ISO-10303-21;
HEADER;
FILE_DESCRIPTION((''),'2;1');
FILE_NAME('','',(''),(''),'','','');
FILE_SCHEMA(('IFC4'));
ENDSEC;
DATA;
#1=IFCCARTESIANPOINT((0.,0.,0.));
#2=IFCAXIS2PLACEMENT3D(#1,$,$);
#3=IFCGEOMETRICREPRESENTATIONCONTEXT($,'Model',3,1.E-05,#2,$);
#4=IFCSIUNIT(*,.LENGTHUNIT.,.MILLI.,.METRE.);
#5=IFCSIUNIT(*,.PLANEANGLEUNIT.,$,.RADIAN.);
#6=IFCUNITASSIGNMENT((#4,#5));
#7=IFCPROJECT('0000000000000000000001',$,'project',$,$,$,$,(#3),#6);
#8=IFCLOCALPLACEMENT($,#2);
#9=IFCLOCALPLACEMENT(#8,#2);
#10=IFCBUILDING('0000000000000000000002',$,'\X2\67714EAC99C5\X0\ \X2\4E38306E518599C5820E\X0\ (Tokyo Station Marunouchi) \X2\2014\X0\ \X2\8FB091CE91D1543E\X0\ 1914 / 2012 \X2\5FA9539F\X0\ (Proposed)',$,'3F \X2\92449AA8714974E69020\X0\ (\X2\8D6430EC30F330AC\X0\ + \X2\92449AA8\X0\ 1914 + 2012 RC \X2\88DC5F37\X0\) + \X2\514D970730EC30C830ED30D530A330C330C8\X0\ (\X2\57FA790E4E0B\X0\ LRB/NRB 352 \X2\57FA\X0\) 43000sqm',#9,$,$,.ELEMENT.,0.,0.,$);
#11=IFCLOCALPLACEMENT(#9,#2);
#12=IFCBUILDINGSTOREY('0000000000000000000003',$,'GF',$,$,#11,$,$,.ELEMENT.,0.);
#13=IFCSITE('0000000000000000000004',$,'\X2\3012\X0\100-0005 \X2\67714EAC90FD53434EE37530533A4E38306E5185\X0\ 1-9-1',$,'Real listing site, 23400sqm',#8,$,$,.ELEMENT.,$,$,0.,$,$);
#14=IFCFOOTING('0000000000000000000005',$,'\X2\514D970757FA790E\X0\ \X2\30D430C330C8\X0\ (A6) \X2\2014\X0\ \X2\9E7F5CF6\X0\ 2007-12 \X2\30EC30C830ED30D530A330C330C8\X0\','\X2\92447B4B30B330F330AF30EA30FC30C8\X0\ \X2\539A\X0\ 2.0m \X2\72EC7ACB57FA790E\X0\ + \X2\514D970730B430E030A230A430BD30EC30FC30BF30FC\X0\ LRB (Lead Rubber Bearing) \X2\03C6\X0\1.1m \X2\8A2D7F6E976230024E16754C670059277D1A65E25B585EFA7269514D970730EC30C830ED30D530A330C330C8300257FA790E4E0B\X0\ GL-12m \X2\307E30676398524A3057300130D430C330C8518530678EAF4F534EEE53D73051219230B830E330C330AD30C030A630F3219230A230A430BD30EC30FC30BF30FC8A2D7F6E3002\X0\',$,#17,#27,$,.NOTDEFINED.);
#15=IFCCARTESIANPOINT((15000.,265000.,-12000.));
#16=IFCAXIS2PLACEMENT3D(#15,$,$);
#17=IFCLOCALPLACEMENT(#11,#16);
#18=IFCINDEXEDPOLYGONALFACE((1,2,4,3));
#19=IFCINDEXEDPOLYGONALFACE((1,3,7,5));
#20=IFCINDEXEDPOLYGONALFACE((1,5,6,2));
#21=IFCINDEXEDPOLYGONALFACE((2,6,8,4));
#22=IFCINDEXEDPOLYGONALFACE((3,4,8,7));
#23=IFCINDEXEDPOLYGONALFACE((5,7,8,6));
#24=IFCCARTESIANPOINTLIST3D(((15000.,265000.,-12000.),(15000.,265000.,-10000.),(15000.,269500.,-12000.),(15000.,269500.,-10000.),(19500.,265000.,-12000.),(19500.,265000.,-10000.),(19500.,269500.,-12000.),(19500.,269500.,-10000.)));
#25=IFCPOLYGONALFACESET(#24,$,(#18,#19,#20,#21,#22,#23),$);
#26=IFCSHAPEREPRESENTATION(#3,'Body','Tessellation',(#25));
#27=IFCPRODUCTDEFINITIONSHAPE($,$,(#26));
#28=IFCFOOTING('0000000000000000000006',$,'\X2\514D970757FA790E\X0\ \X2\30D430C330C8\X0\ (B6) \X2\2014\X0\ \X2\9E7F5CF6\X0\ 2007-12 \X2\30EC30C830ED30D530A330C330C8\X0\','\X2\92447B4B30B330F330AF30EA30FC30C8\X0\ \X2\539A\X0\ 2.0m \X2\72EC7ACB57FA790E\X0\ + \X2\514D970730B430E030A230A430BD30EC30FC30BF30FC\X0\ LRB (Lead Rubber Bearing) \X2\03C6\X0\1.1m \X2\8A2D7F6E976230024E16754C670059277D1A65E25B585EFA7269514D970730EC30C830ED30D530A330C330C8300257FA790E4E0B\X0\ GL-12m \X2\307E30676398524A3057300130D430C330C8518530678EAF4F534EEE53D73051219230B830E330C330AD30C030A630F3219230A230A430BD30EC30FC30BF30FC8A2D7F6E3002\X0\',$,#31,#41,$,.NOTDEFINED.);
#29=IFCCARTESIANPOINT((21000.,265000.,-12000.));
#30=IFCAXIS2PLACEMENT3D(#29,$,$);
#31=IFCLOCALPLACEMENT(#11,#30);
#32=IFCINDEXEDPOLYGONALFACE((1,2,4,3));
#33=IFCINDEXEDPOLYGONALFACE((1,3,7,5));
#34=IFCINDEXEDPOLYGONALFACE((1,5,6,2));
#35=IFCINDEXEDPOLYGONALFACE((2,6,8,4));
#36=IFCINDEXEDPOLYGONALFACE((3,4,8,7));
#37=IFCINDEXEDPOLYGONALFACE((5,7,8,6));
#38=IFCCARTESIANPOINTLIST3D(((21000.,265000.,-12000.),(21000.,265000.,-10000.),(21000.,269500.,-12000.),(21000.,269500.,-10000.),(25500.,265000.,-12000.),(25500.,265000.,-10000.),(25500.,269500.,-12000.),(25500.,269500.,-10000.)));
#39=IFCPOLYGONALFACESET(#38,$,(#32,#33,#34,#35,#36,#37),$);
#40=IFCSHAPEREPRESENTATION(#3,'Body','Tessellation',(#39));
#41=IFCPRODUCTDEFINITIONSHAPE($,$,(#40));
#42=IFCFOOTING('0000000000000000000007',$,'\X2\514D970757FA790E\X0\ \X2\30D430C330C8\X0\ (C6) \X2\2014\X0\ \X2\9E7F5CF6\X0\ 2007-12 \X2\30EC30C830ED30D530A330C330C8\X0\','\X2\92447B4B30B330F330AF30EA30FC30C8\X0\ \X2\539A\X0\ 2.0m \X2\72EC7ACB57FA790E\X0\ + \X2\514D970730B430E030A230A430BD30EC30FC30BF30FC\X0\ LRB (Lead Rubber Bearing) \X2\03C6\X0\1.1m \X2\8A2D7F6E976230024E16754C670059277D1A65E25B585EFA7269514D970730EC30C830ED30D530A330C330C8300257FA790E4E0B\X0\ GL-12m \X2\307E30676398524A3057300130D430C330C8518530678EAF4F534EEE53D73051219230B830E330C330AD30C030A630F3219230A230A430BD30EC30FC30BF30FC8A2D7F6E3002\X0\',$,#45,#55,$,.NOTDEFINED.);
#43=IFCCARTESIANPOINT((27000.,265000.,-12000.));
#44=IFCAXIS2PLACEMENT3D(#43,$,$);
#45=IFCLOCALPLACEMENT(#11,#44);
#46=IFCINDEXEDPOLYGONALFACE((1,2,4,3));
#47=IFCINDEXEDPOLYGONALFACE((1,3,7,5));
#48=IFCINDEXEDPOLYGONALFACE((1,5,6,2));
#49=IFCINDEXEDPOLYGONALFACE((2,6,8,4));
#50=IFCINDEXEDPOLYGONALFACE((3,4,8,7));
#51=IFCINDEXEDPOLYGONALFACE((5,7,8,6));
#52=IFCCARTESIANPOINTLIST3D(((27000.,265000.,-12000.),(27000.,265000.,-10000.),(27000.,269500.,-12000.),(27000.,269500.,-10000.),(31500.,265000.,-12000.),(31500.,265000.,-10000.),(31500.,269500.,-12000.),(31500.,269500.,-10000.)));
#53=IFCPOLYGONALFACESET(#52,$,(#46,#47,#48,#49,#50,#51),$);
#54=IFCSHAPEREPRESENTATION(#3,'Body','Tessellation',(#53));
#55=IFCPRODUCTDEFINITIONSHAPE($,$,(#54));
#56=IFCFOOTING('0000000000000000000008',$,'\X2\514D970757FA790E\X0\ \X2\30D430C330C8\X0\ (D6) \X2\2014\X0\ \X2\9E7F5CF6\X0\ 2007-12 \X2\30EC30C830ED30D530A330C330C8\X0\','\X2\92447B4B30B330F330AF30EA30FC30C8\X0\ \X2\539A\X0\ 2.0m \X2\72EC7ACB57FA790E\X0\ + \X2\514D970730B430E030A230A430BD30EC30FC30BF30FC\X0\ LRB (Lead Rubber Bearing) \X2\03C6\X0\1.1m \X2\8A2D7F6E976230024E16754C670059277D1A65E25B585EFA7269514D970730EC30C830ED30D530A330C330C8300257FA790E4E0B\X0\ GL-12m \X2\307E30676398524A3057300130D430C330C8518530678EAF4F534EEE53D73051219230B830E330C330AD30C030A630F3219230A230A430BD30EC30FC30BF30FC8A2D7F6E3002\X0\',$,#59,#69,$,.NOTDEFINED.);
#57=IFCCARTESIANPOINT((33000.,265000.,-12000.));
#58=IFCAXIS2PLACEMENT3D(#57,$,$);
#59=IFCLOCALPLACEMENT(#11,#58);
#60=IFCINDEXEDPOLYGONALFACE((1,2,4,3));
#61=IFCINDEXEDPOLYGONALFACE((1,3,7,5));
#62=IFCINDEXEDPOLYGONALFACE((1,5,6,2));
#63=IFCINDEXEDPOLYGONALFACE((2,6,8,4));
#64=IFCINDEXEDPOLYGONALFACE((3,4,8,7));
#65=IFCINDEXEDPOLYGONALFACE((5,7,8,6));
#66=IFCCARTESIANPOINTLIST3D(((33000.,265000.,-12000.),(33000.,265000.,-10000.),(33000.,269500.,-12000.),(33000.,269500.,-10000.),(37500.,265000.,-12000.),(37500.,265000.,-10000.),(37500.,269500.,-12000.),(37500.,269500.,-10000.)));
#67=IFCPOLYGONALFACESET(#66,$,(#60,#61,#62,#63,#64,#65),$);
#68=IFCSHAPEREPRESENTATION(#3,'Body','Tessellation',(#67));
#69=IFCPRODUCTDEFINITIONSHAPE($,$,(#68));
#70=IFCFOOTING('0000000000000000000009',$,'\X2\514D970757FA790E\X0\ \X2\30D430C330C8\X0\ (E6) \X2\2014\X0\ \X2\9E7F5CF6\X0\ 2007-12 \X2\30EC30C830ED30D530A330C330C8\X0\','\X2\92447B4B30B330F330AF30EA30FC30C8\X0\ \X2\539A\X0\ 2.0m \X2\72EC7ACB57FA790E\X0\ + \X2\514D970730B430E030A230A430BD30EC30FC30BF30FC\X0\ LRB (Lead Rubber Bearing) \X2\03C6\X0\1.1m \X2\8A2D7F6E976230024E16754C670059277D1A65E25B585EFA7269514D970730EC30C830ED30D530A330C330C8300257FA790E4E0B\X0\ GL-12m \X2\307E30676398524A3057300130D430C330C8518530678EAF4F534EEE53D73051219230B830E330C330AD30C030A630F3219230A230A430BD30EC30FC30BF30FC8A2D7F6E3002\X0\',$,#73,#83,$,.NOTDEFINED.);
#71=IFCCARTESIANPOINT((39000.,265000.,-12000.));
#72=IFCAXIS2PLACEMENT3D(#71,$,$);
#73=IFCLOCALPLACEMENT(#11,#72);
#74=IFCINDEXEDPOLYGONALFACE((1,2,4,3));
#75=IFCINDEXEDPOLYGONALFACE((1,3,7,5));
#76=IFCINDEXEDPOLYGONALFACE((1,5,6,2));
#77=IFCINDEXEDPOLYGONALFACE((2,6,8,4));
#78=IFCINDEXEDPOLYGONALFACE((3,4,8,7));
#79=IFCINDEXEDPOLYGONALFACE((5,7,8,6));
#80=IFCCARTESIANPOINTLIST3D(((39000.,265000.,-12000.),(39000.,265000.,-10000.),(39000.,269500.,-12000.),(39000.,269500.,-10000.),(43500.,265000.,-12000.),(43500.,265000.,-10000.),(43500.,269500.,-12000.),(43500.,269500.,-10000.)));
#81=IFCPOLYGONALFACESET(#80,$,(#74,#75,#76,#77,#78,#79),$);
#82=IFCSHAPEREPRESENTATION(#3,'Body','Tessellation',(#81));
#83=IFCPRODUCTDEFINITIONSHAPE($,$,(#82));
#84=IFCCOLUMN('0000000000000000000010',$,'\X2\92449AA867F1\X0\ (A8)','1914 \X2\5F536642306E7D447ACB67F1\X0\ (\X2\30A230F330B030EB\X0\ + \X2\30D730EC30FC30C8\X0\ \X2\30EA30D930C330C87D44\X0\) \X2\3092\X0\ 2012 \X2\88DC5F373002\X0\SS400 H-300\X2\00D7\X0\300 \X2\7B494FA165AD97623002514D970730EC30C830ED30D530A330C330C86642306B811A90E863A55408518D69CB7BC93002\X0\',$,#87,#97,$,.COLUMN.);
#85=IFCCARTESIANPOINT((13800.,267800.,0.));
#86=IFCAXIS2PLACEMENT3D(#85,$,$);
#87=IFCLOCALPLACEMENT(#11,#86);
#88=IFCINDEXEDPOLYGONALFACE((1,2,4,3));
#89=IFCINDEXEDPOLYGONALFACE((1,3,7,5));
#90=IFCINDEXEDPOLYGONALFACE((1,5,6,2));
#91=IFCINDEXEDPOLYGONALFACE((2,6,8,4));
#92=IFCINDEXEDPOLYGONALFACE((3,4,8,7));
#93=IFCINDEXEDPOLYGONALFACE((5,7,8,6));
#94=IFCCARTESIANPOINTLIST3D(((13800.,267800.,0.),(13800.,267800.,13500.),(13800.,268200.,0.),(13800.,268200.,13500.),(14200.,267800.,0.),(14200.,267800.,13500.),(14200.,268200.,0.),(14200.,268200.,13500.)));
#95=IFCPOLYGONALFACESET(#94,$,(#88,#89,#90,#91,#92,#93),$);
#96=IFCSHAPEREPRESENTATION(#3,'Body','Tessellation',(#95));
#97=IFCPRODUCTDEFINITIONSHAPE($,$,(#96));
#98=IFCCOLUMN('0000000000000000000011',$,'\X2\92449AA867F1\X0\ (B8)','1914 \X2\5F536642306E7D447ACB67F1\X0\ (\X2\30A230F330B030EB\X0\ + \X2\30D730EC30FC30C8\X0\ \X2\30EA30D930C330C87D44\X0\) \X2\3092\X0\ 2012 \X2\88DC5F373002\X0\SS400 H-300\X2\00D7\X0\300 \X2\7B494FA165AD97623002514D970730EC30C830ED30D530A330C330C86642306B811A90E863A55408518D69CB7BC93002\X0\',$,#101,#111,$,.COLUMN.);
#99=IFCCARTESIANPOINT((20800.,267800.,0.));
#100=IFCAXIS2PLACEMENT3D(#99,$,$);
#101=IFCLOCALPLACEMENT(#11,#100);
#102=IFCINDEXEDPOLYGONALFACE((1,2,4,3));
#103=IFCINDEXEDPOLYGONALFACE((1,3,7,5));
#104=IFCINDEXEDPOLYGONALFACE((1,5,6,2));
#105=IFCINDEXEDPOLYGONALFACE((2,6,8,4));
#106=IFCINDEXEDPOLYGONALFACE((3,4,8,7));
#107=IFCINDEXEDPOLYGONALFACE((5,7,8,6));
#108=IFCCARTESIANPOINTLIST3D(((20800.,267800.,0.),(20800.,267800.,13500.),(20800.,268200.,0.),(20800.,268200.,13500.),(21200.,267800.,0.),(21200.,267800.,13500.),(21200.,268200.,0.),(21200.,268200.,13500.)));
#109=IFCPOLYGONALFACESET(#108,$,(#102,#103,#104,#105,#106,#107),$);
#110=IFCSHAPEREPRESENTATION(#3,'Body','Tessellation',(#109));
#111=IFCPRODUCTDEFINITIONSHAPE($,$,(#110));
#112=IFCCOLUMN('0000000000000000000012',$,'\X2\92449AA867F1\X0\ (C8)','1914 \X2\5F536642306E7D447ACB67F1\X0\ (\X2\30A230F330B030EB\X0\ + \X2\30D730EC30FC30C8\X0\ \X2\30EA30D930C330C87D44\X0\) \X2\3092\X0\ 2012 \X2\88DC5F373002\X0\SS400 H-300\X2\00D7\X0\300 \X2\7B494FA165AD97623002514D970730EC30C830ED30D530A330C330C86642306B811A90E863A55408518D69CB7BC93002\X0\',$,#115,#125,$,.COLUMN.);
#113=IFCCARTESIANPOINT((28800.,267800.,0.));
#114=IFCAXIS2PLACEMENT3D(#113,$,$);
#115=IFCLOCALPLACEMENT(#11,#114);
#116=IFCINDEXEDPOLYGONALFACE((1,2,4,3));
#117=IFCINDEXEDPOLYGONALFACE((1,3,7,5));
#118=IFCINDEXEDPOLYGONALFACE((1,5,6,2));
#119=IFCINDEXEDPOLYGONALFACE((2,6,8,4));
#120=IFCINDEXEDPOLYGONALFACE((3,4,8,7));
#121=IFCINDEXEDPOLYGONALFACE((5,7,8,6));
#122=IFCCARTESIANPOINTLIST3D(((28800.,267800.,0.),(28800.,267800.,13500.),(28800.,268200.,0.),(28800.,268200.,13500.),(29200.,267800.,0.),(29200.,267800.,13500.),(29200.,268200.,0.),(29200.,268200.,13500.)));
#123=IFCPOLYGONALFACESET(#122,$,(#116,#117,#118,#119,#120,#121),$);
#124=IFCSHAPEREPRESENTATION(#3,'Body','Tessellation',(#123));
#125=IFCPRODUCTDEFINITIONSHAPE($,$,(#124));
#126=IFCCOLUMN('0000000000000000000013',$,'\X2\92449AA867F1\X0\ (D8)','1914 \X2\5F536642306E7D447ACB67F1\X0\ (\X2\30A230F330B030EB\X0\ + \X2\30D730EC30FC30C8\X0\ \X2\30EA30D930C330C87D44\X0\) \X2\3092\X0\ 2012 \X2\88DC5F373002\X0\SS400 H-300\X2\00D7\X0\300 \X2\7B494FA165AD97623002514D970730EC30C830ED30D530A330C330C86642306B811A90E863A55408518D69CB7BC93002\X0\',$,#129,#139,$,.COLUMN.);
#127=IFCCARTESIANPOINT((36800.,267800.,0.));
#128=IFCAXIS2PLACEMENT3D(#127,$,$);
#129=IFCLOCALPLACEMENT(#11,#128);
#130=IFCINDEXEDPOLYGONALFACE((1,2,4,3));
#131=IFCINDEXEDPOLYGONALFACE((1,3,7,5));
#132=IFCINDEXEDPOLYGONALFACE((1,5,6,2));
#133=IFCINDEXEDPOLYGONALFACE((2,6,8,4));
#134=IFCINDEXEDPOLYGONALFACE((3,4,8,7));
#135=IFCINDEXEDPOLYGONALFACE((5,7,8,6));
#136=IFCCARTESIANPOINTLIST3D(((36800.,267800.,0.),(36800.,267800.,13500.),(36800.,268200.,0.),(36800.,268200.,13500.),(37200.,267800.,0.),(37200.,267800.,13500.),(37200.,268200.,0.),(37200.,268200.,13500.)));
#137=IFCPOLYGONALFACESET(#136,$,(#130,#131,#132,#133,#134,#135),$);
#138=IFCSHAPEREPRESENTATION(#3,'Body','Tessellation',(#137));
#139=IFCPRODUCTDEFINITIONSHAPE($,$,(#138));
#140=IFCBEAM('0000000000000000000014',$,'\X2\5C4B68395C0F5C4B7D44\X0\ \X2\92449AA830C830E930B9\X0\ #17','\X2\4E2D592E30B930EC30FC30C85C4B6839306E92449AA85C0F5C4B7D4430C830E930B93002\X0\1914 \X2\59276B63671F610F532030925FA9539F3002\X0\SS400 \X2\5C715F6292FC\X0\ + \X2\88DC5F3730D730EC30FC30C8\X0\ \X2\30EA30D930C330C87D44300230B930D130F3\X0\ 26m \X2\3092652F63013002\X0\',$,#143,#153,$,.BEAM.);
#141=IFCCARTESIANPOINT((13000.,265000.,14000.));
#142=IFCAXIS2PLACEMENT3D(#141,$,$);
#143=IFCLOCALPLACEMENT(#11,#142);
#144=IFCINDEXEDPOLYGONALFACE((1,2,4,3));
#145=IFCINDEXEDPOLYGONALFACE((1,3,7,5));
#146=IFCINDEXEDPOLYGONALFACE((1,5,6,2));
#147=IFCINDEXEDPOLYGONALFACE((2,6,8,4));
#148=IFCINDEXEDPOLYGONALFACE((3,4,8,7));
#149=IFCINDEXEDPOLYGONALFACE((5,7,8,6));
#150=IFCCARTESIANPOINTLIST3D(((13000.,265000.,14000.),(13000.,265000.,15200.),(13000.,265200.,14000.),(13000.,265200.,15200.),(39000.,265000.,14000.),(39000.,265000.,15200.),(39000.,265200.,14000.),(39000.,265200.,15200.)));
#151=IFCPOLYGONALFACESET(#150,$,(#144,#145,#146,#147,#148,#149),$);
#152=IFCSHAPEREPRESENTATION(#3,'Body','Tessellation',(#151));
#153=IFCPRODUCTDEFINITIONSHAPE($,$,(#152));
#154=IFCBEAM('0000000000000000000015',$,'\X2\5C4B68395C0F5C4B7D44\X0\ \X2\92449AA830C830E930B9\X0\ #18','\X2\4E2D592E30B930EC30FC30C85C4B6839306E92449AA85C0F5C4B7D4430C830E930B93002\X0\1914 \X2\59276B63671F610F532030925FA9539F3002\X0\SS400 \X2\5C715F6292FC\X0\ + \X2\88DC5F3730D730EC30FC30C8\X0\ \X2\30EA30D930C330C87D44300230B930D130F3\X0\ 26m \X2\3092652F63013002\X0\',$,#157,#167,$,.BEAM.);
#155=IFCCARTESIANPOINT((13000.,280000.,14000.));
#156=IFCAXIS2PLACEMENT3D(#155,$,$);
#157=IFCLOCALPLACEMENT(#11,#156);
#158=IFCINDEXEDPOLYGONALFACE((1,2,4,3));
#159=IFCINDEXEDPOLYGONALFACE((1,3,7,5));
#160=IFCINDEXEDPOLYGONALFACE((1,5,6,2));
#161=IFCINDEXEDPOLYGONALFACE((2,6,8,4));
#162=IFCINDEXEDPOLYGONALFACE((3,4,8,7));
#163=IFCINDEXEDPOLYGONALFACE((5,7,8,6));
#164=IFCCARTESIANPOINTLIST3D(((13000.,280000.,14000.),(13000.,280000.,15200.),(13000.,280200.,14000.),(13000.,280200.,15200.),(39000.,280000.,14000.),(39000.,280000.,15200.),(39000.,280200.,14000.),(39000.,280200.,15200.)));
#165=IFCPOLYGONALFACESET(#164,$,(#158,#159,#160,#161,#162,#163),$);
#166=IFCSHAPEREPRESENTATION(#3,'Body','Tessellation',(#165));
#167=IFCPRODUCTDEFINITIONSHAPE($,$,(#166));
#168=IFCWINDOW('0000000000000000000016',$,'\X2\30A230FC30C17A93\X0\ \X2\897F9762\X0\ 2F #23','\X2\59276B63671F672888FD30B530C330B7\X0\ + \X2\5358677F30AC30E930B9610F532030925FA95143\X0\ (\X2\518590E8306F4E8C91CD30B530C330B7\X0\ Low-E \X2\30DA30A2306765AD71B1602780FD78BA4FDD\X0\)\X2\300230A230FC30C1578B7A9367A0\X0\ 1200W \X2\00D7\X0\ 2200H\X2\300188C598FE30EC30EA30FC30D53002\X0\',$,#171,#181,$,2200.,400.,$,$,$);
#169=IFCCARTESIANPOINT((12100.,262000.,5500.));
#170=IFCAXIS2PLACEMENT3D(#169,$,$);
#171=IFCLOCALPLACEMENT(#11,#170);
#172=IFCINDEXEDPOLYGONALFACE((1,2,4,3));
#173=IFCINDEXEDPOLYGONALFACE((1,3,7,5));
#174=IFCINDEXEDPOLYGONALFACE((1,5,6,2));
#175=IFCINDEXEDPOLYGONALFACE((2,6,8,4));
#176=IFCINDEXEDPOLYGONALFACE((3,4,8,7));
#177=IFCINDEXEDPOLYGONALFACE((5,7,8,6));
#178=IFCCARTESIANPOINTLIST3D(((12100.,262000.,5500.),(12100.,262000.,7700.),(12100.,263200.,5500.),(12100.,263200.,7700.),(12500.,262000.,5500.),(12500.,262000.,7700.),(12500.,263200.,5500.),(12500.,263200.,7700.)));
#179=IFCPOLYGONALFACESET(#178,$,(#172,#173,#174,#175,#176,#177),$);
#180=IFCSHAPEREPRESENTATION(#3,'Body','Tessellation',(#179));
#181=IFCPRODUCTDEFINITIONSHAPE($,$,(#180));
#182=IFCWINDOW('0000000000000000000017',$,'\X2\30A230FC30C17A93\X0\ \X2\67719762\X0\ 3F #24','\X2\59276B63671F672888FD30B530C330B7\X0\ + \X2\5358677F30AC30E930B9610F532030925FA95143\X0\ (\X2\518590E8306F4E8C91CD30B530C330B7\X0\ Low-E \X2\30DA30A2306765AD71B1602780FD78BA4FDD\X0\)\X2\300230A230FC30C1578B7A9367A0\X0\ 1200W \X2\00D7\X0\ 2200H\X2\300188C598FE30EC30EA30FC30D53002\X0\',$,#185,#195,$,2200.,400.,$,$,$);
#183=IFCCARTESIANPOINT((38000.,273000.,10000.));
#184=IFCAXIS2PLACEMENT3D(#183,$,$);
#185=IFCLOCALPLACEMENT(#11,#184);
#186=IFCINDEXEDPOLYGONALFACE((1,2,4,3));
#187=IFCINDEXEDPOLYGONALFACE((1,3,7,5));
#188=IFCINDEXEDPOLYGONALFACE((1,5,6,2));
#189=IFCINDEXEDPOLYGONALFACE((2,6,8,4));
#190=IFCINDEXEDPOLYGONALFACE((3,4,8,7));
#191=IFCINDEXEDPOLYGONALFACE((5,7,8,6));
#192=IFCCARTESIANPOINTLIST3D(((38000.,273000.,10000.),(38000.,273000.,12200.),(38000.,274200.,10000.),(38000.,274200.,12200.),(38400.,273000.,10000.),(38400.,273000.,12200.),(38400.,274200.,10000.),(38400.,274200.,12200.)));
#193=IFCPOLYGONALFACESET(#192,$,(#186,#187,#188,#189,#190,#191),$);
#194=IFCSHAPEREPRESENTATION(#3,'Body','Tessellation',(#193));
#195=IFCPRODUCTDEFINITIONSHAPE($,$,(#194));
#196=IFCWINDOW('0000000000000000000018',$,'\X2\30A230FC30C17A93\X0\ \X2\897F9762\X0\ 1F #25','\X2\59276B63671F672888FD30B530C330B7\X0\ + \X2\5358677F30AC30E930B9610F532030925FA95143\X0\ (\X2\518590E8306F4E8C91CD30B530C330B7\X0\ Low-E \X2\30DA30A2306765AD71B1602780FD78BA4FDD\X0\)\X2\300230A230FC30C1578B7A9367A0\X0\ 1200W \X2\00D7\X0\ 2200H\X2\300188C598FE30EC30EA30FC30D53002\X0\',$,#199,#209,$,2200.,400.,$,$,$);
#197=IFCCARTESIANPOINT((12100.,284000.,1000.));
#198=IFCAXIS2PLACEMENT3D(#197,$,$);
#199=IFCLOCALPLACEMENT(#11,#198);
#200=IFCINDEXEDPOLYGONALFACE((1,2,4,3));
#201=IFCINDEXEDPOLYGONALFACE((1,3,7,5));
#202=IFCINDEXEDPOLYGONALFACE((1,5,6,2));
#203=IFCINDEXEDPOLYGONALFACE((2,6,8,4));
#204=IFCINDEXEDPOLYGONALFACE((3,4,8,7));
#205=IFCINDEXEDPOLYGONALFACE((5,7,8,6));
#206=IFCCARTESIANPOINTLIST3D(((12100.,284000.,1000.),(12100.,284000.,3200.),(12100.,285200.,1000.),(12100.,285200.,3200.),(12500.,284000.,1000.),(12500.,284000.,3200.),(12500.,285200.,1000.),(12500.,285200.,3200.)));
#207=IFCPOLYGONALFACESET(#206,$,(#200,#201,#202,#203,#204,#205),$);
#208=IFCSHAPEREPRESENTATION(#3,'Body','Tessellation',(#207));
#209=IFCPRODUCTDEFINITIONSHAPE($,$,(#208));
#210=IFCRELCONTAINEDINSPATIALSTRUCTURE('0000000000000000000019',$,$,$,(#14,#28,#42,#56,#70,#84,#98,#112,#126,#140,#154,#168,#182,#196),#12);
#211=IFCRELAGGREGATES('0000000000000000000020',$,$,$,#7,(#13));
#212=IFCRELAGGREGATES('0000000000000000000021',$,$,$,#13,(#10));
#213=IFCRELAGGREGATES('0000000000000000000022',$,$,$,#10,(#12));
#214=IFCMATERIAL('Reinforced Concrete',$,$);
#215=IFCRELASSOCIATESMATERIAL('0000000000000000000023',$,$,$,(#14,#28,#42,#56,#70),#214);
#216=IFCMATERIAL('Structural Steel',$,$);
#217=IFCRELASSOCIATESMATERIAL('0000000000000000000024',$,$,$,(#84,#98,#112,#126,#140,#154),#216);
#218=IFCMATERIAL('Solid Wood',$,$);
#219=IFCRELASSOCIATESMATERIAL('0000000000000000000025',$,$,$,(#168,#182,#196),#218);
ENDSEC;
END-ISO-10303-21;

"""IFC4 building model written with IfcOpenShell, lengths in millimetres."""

from ifc_helpers import new_model, si_unit, frame, frame_2d, origin, place, context, project, spatial, rectangle, extrude, material, element, save


model = new_model("IFC4")

# Units and contexts
model_context = context("Model", 3, precision=1e-05, world=origin())
ifc_project = project(units=[si_unit("LENGTHUNIT", "METRE", prefix="MILLI"), si_unit("PLANEANGLEUNIT", "RADIAN")], contexts=[model_context])

# Site, building, storey
site_placement = place(None, origin())
site = spatial("IfcSite", under=ifc_project, at=site_placement, Name="〒100-0005 東京都千代田区丸の内 1-9-1", ObjectType="Real listing site, 23400sqm", CompositionType="ELEMENT", RefElevation=0.0)
building_placement = place(site_placement, origin())
building = spatial("IfcBuilding", under=site, at=building_placement, Name="東京駅 丸の内駅舎 (Tokyo Station Marunouchi) — 辰野金吾 1914 / 2012 復原 (Proposed)", ObjectType="3F 鉄骨煉瓦造 (赤レンガ + 鉄骨 1914 + 2012 RC 補強) + 免震レトロフィット (基礎下 LRB/NRB 352 基) 43000sqm", CompositionType="ELEMENT", ElevationOfRefHeight=0.0, ElevationOfTerrain=0.0)
storey_placement = place(building_placement, origin())
storey = spatial("IfcBuildingStorey", under=building, at=storey_placement, Name="GF", CompositionType="ELEMENT", Elevation=0.0)

# Footings
ifc_material_1 = material(Name="Reinforced Concrete")
footing_1_placement = place(storey_placement, frame((15000.0, 265000.0, -12000.0)))
element("IfcFooting", 1, at=footing_1_placement, inside=storey, material=ifc_material_1, Name="免震基礎 ピット (A6) — 鹿島 2007-12 レトロフィット", Description="鉄筋コンクリート 厚 2.0m 独立基礎 + 免震ゴムアイソレーター LRB (Lead Rubber Bearing) φ1.1m 設置面。世界最大級既存建物免震レトロフィット。基礎下 GL-12m まで掘削し、ピット内で躯体仮受け→ジャッキダウン→アイソレーター設置。", PredefinedType="NOTDEFINED", context=model_context, shape_type="SweptSolid", body=[
    extrude(rectangle(XDim=4500.0, YDim=4500.0, at=frame_2d((2250.0, 2250.0))), frame((15000.0, 265000.0, -12000.0)), (0.0, 0.0, 1.0), 2000.0),
])
footing_2_placement = place(storey_placement, frame((21000.0, 265000.0, -12000.0)))
element("IfcFooting", 2, at=footing_2_placement, inside=storey, material=ifc_material_1, Name="免震基礎 ピット (B6) — 鹿島 2007-12 レトロフィット", Description="鉄筋コンクリート 厚 2.0m 独立基礎 + 免震ゴムアイソレーター LRB (Lead Rubber Bearing) φ1.1m 設置面。世界最大級既存建物免震レトロフィット。基礎下 GL-12m まで掘削し、ピット内で躯体仮受け→ジャッキダウン→アイソレーター設置。", PredefinedType="NOTDEFINED", context=model_context, shape_type="SweptSolid", body=[
    extrude(rectangle(XDim=4500.0, YDim=4500.0, at=frame_2d((2250.0, 2250.0))), frame((21000.0, 265000.0, -12000.0)), (0.0, 0.0, 1.0), 2000.0),
])
footing_3_placement = place(storey_placement, frame((27000.0, 265000.0, -12000.0)))
element("IfcFooting", 3, at=footing_3_placement, inside=storey, material=ifc_material_1, Name="免震基礎 ピット (C6) — 鹿島 2007-12 レトロフィット", Description="鉄筋コンクリート 厚 2.0m 独立基礎 + 免震ゴムアイソレーター LRB (Lead Rubber Bearing) φ1.1m 設置面。世界最大級既存建物免震レトロフィット。基礎下 GL-12m まで掘削し、ピット内で躯体仮受け→ジャッキダウン→アイソレーター設置。", PredefinedType="NOTDEFINED", context=model_context, shape_type="SweptSolid", body=[
    extrude(rectangle(XDim=4500.0, YDim=4500.0, at=frame_2d((2250.0, 2250.0))), frame((27000.0, 265000.0, -12000.0)), (0.0, 0.0, 1.0), 2000.0),
])
footing_4_placement = place(storey_placement, frame((33000.0, 265000.0, -12000.0)))
element("IfcFooting", 4, at=footing_4_placement, inside=storey, material=ifc_material_1, Name="免震基礎 ピット (D6) — 鹿島 2007-12 レトロフィット", Description="鉄筋コンクリート 厚 2.0m 独立基礎 + 免震ゴムアイソレーター LRB (Lead Rubber Bearing) φ1.1m 設置面。世界最大級既存建物免震レトロフィット。基礎下 GL-12m まで掘削し、ピット内で躯体仮受け→ジャッキダウン→アイソレーター設置。", PredefinedType="NOTDEFINED", context=model_context, shape_type="SweptSolid", body=[
    extrude(rectangle(XDim=4500.0, YDim=4500.0, at=frame_2d((2250.0, 2250.0))), frame((33000.0, 265000.0, -12000.0)), (0.0, 0.0, 1.0), 2000.0),
])
footing_5_placement = place(storey_placement, frame((39000.0, 265000.0, -12000.0)))
element("IfcFooting", 5, at=footing_5_placement, inside=storey, material=ifc_material_1, Name="免震基礎 ピット (E6) — 鹿島 2007-12 レトロフィット", Description="鉄筋コンクリート 厚 2.0m 独立基礎 + 免震ゴムアイソレーター LRB (Lead Rubber Bearing) φ1.1m 設置面。世界最大級既存建物免震レトロフィット。基礎下 GL-12m まで掘削し、ピット内で躯体仮受け→ジャッキダウン→アイソレーター設置。", PredefinedType="NOTDEFINED", context=model_context, shape_type="SweptSolid", body=[
    extrude(rectangle(XDim=4500.0, YDim=4500.0, at=frame_2d((2250.0, 2250.0))), frame((39000.0, 265000.0, -12000.0)), (0.0, 0.0, 1.0), 2000.0),
])

# Columns
ifc_material_2 = material(Name="Structural Steel")
column_1_placement = place(storey_placement, frame((13800.0, 267800.0, 0.0)))
element("IfcColumn", 6, at=column_1_placement, inside=storey, material=ifc_material_2, Name="鉄骨柱 (A8)", Description="1914 当時の組立柱 (アングル + プレート リベット組) を 2012 補強。SS400 H-300×300 等価断面。免震レトロフィット時に脚部接合再構築。", PredefinedType="COLUMN", context=model_context, shape_type="SweptSolid", body=[
    extrude(rectangle(XDim=400.0, YDim=400.0, at=frame_2d((200.0, 200.0))), frame((13800.0, 267800.0, 0.0)), (0.0, 0.0, 1.0), 13500.0),
])
column_2_placement = place(storey_placement, frame((20800.0, 267800.0, 0.0)))
element("IfcColumn", 7, at=column_2_placement, inside=storey, material=ifc_material_2, Name="鉄骨柱 (B8)", Description="1914 当時の組立柱 (アングル + プレート リベット組) を 2012 補強。SS400 H-300×300 等価断面。免震レトロフィット時に脚部接合再構築。", PredefinedType="COLUMN", context=model_context, shape_type="SweptSolid", body=[
    extrude(rectangle(XDim=400.0, YDim=400.0, at=frame_2d((200.0, 200.0))), frame((20800.0, 267800.0, 0.0)), (0.0, 0.0, 1.0), 13500.0),
])
column_3_placement = place(storey_placement, frame((28800.0, 267800.0, 0.0)))
element("IfcColumn", 8, at=column_3_placement, inside=storey, material=ifc_material_2, Name="鉄骨柱 (C8)", Description="1914 当時の組立柱 (アングル + プレート リベット組) を 2012 補強。SS400 H-300×300 等価断面。免震レトロフィット時に脚部接合再構築。", PredefinedType="COLUMN", context=model_context, shape_type="SweptSolid", body=[
    extrude(rectangle(XDim=400.0, YDim=400.0, at=frame_2d((200.0, 200.0))), frame((28800.0, 267800.0, 0.0)), (0.0, 0.0, 1.0), 13500.0),
])
column_4_placement = place(storey_placement, frame((36800.0, 267800.0, 0.0)))
element("IfcColumn", 9, at=column_4_placement, inside=storey, material=ifc_material_2, Name="鉄骨柱 (D8)", Description="1914 当時の組立柱 (アングル + プレート リベット組) を 2012 補強。SS400 H-300×300 等価断面。免震レトロフィット時に脚部接合再構築。", PredefinedType="COLUMN", context=model_context, shape_type="SweptSolid", body=[
    extrude(rectangle(XDim=400.0, YDim=400.0, at=frame_2d((200.0, 200.0))), frame((36800.0, 267800.0, 0.0)), (0.0, 0.0, 1.0), 13500.0),
])

# Beams
beam_1_placement = place(storey_placement, frame((13000.0, 265000.0, 14000.0)))
element("IfcBeam", 10, at=beam_1_placement, inside=storey, material=ifc_material_2, Name="屋根小屋組 鉄骨トラス #17", Description="中央スレート屋根の鉄骨小屋組トラス。1914 大正期意匠を復原。SS400 山形鋼 + 補強プレート リベット組。スパン 26m を支持。", PredefinedType="BEAM", context=model_context, shape_type="SweptSolid", body=[
    extrude(rectangle(XDim=26000.0, YDim=200.0, at=frame_2d((13000.0, 100.0))), frame((13000.0, 265000.0, 14000.0)), (0.0, 0.0, 1.0), 1200.0),
])
beam_2_placement = place(storey_placement, frame((13000.0, 280000.0, 14000.0)))
element("IfcBeam", 11, at=beam_2_placement, inside=storey, material=ifc_material_2, Name="屋根小屋組 鉄骨トラス #18", Description="中央スレート屋根の鉄骨小屋組トラス。1914 大正期意匠を復原。SS400 山形鋼 + 補強プレート リベット組。スパン 26m を支持。", PredefinedType="BEAM", context=model_context, shape_type="SweptSolid", body=[
    extrude(rectangle(XDim=26000.0, YDim=200.0, at=frame_2d((13000.0, 100.0))), frame((13000.0, 280000.0, 14000.0)), (0.0, 0.0, 1.0), 1200.0),
])

# Windows
ifc_material_3 = material(Name="Solid Wood")
window_1_placement = place(storey_placement, frame((12100.0, 262000.0, 5500.0)))
element("IfcWindow", 12, at=window_1_placement, inside=storey, material=ifc_material_3, Name="アーチ窓 西面 2F #23", Description="大正期木製サッシ + 単板ガラス意匠を復元 (内部は二重サッシ Low-E ペアで断熱性能確保)。アーチ型窓枠 1200W × 2200H、装飾レリーフ。", OverallHeight=2200.0, OverallWidth=400.0, context=model_context, shape_type="SweptSolid", body=[
    extrude(rectangle(XDim=400.0, YDim=1200.0, at=frame_2d((200.0, 600.0))), frame((12100.0, 262000.0, 5500.0)), (0.0, 0.0, 1.0), 2200.0),
])
window_2_placement = place(storey_placement, frame((38000.0, 273000.0, 10000.0)))
element("IfcWindow", 13, at=window_2_placement, inside=storey, material=ifc_material_3, Name="アーチ窓 東面 3F #24", Description="大正期木製サッシ + 単板ガラス意匠を復元 (内部は二重サッシ Low-E ペアで断熱性能確保)。アーチ型窓枠 1200W × 2200H、装飾レリーフ。", OverallHeight=2200.0, OverallWidth=400.0, context=model_context, shape_type="SweptSolid", body=[
    extrude(rectangle(XDim=400.0, YDim=1200.0, at=frame_2d((200.0, 600.0))), frame((38000.0, 273000.0, 10000.0)), (0.0, 0.0, 1.0), 2200.0),
])
window_3_placement = place(storey_placement, frame((12100.0, 284000.0, 1000.0)))
element("IfcWindow", 14, at=window_3_placement, inside=storey, material=ifc_material_3, Name="アーチ窓 西面 1F #25", Description="大正期木製サッシ + 単板ガラス意匠を復元 (内部は二重サッシ Low-E ペアで断熱性能確保)。アーチ型窓枠 1200W × 2200H、装飾レリーフ。", OverallHeight=2200.0, OverallWidth=400.0, context=model_context, shape_type="SweptSolid", body=[
    extrude(rectangle(XDim=400.0, YDim=1200.0, at=frame_2d((200.0, 600.0))), frame((12100.0, 284000.0, 1000.0)), (0.0, 0.0, 1.0), 2200.0),
])

save(model, "model.ifc")
